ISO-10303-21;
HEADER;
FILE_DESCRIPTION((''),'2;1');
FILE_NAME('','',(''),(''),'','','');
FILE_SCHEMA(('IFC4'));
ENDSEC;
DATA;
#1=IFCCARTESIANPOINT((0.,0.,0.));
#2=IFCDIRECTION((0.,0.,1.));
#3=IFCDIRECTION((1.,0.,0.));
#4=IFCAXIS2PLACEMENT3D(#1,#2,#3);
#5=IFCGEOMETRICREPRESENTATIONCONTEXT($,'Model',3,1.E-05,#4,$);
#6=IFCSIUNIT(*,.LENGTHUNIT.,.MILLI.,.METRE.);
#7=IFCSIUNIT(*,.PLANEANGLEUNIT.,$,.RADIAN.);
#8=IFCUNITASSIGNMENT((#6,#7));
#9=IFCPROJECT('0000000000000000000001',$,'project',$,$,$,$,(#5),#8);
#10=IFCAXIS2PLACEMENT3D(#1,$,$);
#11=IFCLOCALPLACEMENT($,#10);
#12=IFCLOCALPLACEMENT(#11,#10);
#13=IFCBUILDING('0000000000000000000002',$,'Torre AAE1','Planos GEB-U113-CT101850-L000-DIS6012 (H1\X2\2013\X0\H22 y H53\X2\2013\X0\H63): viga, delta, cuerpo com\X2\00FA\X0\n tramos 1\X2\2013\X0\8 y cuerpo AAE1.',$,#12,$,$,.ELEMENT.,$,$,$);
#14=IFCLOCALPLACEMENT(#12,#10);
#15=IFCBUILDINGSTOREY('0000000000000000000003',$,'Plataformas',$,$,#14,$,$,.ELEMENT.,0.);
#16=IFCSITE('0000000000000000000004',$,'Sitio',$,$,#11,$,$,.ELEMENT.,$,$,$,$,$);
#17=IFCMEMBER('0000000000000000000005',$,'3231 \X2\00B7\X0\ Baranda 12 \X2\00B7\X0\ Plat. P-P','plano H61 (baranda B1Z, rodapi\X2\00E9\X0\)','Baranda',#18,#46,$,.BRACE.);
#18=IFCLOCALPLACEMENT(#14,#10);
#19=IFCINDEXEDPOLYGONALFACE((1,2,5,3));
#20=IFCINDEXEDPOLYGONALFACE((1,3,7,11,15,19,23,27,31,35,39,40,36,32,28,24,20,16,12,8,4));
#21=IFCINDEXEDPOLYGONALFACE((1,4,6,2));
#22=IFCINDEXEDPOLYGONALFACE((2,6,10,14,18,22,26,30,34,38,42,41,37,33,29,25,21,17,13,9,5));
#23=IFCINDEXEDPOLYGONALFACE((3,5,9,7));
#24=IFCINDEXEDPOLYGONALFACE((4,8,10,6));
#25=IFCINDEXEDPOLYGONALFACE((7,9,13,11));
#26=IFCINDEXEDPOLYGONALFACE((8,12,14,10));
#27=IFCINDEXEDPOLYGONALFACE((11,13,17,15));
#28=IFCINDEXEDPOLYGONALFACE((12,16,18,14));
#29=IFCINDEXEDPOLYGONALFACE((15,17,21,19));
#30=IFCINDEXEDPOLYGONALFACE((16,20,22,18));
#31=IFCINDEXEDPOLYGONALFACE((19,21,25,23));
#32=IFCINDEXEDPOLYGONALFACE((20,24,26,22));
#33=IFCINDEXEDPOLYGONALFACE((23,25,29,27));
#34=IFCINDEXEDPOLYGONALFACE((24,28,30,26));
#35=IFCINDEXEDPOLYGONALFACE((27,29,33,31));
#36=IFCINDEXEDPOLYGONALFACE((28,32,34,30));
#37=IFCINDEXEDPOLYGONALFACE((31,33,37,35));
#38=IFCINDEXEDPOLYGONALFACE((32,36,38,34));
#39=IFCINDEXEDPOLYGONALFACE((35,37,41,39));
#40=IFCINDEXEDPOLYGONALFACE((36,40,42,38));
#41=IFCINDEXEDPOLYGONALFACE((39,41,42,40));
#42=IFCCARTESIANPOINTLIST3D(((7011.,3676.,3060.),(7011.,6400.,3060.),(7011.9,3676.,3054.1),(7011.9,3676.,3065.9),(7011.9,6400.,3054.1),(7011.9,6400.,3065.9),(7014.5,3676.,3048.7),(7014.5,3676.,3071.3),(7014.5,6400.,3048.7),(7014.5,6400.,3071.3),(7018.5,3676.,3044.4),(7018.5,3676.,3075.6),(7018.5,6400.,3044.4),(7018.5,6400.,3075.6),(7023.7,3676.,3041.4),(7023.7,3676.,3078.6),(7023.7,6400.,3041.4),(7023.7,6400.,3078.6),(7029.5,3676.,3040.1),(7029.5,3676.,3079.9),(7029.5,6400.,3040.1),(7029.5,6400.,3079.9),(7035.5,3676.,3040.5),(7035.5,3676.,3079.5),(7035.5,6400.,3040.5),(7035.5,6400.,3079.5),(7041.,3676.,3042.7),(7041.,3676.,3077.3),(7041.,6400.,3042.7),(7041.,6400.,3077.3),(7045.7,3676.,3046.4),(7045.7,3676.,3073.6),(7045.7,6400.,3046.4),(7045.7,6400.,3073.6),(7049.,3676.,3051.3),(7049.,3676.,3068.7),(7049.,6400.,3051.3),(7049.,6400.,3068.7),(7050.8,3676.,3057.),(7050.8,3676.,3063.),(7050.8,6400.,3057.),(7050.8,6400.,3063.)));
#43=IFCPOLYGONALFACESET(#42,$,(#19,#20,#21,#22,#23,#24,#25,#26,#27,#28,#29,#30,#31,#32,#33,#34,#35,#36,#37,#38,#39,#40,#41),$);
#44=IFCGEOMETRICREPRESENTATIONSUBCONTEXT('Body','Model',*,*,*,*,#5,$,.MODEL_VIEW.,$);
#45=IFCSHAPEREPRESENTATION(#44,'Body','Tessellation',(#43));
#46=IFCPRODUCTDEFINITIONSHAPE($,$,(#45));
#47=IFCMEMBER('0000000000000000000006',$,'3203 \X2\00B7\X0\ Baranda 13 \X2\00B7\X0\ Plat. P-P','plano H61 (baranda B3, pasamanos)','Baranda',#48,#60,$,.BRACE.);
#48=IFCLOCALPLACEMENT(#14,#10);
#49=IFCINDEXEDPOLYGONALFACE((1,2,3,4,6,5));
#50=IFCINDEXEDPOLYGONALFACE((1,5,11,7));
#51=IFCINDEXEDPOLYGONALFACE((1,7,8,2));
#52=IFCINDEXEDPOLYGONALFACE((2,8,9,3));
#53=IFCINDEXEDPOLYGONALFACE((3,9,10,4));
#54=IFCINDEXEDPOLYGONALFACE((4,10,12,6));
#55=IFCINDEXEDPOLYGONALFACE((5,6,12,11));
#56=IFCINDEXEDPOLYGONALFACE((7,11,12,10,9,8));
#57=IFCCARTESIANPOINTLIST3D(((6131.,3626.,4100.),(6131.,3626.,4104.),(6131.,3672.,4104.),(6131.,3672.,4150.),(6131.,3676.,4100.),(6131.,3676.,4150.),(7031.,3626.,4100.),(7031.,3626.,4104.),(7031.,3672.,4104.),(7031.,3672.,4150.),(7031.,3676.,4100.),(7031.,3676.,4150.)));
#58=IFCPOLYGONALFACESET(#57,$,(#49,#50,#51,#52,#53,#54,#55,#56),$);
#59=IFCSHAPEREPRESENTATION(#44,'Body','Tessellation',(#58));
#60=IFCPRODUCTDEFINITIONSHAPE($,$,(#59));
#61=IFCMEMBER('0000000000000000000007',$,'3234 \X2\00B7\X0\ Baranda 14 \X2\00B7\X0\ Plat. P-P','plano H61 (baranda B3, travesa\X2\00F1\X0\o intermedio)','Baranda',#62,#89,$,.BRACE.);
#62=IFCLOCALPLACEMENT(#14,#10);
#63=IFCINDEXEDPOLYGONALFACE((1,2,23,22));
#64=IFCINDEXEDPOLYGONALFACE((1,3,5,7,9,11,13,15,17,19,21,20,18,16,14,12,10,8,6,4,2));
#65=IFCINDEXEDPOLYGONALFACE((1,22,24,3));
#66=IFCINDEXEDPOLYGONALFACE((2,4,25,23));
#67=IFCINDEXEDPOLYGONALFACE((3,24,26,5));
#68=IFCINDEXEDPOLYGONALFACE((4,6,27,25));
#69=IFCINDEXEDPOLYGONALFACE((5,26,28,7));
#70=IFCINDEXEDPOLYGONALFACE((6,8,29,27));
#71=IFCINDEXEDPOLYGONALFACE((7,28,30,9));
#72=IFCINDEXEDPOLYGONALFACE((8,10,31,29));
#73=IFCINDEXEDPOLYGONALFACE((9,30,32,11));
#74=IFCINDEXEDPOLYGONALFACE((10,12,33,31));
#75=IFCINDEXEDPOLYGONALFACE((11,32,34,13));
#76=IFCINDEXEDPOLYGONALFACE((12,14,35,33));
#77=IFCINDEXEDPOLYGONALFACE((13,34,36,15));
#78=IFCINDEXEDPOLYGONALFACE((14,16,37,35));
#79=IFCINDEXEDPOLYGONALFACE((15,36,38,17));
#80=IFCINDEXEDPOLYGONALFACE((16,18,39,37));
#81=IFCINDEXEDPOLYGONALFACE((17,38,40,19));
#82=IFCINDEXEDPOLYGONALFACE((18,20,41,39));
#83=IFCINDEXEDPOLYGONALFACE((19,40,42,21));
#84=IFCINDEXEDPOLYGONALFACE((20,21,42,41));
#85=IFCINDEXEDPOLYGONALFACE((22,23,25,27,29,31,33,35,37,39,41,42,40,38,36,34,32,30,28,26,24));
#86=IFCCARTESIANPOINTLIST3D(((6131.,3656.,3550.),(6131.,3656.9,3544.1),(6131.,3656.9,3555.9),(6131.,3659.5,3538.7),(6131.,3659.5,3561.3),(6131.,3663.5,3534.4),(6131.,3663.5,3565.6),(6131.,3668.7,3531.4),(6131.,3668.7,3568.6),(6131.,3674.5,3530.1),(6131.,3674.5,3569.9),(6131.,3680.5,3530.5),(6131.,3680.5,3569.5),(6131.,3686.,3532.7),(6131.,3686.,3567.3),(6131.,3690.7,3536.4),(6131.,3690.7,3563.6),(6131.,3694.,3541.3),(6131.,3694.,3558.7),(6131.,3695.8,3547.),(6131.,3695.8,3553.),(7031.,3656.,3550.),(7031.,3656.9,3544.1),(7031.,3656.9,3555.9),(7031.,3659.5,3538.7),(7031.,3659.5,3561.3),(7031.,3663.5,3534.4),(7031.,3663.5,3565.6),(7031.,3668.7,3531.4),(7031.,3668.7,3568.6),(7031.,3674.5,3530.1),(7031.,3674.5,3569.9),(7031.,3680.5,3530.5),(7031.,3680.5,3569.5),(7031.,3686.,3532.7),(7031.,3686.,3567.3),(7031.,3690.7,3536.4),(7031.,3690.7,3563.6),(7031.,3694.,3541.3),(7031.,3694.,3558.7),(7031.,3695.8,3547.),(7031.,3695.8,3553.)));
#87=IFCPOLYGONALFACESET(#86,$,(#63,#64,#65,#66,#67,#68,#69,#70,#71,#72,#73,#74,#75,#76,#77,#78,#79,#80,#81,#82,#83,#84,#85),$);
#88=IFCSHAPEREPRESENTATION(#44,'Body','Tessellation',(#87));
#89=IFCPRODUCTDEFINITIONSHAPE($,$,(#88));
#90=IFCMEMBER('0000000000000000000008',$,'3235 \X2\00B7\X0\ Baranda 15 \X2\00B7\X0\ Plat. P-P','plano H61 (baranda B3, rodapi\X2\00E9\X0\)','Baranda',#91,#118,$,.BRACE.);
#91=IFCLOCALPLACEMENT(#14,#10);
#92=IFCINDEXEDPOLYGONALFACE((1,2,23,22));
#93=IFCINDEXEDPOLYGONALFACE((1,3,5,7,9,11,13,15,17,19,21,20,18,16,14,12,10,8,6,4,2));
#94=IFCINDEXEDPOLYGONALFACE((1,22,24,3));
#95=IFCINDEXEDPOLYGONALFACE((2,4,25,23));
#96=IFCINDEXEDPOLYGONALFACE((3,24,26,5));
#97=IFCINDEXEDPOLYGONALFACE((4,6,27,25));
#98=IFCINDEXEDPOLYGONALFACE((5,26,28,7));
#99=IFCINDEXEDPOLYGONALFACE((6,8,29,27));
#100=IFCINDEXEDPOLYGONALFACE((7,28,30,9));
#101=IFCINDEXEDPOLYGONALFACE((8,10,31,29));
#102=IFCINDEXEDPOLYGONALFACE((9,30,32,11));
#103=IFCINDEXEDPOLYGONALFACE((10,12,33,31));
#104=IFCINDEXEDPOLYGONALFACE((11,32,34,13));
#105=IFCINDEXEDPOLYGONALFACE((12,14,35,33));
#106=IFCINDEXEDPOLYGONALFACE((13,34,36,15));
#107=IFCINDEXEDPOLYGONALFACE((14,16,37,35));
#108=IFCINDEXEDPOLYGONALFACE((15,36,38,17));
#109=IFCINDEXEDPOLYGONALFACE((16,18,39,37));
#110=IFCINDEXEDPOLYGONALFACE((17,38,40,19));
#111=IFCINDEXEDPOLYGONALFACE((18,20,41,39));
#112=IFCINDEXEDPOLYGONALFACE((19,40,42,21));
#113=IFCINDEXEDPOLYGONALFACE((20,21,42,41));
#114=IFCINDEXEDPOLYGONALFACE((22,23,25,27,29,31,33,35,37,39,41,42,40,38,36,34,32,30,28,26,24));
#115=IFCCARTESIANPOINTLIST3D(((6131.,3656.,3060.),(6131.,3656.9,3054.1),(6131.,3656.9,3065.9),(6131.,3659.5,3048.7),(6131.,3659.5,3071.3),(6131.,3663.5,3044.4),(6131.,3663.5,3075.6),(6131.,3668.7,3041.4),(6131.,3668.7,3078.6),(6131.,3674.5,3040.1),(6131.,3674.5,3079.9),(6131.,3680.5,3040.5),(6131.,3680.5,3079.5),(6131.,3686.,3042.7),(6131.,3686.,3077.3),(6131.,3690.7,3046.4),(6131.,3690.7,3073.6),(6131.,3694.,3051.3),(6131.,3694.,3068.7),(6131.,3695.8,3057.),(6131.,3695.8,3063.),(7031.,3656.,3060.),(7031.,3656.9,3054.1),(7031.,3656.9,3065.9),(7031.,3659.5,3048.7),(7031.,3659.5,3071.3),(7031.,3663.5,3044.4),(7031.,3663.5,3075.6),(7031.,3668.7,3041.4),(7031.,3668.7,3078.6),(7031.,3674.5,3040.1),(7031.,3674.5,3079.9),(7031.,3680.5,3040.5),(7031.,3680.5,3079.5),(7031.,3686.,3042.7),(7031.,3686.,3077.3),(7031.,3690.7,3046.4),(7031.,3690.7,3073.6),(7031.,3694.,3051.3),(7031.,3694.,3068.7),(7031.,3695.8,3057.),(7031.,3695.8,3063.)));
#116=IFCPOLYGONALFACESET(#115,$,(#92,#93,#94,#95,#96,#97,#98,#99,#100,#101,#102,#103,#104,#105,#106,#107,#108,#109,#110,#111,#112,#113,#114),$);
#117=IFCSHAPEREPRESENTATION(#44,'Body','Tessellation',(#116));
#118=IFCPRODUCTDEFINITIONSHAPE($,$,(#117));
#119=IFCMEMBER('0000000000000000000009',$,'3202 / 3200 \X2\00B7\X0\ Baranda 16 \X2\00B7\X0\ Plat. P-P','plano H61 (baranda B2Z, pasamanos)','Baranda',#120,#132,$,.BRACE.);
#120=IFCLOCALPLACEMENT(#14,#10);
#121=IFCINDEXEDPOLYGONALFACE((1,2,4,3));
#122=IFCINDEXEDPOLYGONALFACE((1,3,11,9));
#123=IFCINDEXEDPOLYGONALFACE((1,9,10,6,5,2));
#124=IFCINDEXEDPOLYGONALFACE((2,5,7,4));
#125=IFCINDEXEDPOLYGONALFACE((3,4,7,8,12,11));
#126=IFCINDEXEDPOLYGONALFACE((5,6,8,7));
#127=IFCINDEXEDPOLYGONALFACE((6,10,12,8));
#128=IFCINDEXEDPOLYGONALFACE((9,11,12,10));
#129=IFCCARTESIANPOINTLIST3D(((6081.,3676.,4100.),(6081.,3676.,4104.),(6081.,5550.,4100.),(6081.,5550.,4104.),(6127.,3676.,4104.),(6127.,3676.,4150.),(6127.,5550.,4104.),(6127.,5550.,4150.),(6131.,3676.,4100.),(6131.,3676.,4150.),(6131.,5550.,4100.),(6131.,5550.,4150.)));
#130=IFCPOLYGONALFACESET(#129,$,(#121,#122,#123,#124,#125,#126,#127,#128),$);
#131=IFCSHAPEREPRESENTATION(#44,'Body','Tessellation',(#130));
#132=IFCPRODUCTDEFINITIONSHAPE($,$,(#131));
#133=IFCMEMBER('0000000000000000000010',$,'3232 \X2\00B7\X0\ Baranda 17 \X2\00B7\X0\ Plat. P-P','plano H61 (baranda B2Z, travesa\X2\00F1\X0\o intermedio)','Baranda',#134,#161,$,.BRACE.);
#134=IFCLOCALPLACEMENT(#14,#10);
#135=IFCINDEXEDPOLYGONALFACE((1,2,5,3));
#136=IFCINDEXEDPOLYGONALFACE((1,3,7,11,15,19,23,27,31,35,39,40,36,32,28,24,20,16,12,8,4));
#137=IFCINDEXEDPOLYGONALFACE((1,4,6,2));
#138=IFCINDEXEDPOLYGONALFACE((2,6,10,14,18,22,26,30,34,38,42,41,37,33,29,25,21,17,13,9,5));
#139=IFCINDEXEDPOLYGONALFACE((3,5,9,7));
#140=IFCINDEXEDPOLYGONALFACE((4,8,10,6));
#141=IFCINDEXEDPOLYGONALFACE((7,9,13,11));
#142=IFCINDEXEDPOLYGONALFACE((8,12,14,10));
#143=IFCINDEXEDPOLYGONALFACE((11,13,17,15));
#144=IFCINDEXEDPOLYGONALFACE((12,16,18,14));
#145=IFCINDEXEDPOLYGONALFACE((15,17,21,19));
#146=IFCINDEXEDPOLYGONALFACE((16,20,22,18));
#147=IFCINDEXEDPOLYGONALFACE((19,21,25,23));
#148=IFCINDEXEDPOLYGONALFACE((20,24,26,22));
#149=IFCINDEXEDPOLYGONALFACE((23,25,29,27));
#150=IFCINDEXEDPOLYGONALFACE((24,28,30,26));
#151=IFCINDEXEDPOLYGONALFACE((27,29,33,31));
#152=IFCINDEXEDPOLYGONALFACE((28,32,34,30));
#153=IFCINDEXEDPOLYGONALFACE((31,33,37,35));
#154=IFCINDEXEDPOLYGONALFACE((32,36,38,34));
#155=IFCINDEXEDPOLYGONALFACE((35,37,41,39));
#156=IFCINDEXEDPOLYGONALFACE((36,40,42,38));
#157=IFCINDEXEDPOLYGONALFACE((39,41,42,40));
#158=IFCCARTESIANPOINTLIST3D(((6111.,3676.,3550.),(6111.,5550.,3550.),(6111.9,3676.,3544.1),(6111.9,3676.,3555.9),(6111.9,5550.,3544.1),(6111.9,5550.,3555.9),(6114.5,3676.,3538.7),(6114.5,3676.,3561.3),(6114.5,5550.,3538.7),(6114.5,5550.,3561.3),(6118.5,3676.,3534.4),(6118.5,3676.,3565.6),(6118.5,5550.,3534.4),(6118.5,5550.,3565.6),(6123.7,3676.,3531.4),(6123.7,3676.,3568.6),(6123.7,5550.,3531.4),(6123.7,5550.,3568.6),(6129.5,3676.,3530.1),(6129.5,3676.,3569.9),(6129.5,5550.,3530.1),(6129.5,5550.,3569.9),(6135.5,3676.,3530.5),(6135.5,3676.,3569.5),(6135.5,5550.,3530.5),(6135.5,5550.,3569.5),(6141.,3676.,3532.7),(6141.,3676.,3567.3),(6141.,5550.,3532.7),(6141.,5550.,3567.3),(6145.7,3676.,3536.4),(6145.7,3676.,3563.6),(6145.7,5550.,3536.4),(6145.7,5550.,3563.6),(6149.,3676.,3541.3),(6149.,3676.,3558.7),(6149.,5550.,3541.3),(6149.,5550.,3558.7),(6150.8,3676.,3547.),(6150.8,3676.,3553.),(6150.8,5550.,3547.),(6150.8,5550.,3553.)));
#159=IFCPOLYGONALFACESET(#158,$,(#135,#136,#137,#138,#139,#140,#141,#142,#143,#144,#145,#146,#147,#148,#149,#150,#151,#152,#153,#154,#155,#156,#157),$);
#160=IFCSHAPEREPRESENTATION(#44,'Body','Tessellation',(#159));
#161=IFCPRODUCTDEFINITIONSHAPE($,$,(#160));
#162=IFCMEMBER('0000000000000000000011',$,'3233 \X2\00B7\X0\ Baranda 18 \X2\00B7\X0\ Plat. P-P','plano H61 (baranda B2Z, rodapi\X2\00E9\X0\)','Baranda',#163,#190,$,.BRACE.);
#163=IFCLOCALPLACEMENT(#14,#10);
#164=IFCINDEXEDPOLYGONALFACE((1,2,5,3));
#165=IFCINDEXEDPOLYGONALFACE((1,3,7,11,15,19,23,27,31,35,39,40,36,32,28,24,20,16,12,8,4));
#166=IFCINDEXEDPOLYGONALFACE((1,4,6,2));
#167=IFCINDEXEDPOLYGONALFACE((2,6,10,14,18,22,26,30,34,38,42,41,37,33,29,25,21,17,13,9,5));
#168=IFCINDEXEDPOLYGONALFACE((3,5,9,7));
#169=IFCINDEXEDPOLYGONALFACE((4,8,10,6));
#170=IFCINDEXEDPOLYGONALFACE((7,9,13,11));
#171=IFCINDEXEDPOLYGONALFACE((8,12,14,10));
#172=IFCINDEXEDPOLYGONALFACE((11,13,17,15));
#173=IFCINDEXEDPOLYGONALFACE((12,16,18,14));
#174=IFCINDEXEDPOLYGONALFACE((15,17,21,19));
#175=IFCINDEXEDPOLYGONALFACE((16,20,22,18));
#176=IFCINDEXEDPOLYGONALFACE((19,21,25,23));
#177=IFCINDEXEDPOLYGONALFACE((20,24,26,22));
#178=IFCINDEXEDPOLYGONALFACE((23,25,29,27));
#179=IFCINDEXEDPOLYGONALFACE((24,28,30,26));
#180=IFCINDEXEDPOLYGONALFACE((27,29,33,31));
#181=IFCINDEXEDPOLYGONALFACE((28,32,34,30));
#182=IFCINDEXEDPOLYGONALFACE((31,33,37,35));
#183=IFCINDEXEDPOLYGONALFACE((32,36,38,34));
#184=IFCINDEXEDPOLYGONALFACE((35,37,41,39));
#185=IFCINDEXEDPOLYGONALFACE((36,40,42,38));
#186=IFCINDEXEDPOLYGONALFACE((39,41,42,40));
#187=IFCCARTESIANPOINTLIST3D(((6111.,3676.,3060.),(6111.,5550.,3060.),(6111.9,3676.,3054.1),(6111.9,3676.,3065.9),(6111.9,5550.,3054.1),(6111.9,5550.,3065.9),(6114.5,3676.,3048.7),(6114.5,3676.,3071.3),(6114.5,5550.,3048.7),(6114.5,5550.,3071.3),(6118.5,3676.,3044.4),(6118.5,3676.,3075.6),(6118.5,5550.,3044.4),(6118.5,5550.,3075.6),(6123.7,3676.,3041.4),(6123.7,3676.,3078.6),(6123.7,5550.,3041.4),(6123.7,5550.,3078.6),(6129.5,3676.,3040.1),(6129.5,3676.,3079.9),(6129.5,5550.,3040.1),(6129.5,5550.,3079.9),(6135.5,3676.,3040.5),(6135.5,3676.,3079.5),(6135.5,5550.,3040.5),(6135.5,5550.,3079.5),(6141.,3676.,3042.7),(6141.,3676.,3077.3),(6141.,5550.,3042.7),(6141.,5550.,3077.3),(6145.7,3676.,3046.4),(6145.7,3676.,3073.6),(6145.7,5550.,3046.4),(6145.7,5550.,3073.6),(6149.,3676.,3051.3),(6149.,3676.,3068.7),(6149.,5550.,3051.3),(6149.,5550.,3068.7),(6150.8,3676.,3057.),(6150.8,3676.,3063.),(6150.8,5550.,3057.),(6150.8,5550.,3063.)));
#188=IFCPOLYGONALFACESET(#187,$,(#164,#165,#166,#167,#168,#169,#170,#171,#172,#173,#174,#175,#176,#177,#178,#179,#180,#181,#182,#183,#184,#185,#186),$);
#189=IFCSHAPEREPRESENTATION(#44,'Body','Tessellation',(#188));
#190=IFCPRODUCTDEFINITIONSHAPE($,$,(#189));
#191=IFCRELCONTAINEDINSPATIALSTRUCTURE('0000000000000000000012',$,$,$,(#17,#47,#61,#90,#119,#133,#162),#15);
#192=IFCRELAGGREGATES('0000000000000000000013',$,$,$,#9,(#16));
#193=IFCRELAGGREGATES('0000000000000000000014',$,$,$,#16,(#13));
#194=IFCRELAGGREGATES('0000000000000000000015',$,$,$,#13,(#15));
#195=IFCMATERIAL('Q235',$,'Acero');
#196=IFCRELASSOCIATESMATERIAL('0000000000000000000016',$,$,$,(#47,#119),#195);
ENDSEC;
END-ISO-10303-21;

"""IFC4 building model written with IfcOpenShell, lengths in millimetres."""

from ifc_helpers import new_model, si_unit, frame, frame_2d, origin, origin_with_axes, place, context, subcontext, project, spatial, circle, l_section, extrude, material, element, save


model = new_model("IFC4")

# Units and contexts
model_context = context("Model", 3, precision=1e-05, world=origin_with_axes())
body_context = subcontext(model_context, "Body", "Model", "MODEL_VIEW")
ifc_project = project(units=[si_unit("LENGTHUNIT", "METRE", prefix="MILLI"), si_unit("PLANEANGLEUNIT", "RADIAN")], contexts=[model_context])

# Site, building, storey
site_placement = place(None, origin())
site = spatial("IfcSite", under=ifc_project, at=site_placement, Name="Sitio", CompositionType="ELEMENT")
building_placement = place(site_placement, origin())
building = spatial("IfcBuilding", under=site, at=building_placement, Name="Torre AAE1", Description="Planos GEB-U113-CT101850-L000-DIS6012 (H1–H22 y H53–H63): viga, delta, cuerpo común tramos 1–8 y cuerpo AAE1.", CompositionType="ELEMENT")
storey_placement = place(building_placement, origin())
storey = spatial("IfcBuildingStorey", under=building, at=storey_placement, Name="Plataformas", CompositionType="ELEMENT", Elevation=0.0)

# Members
ifc_material = material(Name="Q235", Category="Acero")
for number, where, z_axis, x_axis, name in (
    (1, (7031.0, 6400.0, 3060.0), (0.0, -1.0, 0.0), (-1.0, 0.0, 0.0), "3231 · Baranda 12 · Plat. P-P"),
):
    element("IfcMember", number, at=place(storey_placement, frame(where, z_axis=z_axis, x_axis=x_axis)), inside=storey, Name=name, Description="plano H61 (baranda B1Z, rodapié)", ObjectType="Baranda", PredefinedType="BRACE", context=body_context, shape_type="SweptSolid", body=[
        extrude(circle(Radius=20.0), None, (0.0, 0.0, 1.0), 2724.0),
    ])
member_1_placement = place(storey_placement, frame((7031.0, 3676.0, 4100.0), z_axis=(-1.0, 0.0, 0.0), x_axis=(0.0, -1.0, 0.0)))
element("IfcMember", 2, at=member_1_placement, inside=storey, material=ifc_material, Name="3203 · Baranda 13 · Plat. P-P", Description="plano H61 (baranda B3, pasamanos)", ObjectType="Baranda", PredefinedType="BRACE", context=body_context, shape_type="SweptSolid", body=[
    extrude(l_section(Depth=50.0, Width=50.0, Thickness=4.0, at=frame_2d((25.0, 25.0))), None, (0.0, 0.0, 1.0), 900.0),
])
for number, where, z_axis, x_axis, name, description in (
    (3, (7031.0, 3676.0, 3550.0), (-1.0, 0.0, 0.0), (0.0, -1.0, 0.0), "3234 · Baranda 14 · Plat. P-P", "plano H61 (baranda B3, travesaño intermedio)"),
    (4, (7031.0, 3676.0, 3060.0), (-1.0, 0.0, 0.0), (0.0, -1.0, 0.0), "3235 · Baranda 15 · Plat. P-P", "plano H61 (baranda B3, rodapié)"),
):
    element("IfcMember", number, at=place(storey_placement, frame(where, z_axis=z_axis, x_axis=x_axis)), inside=storey, Name=name, Description=description, ObjectType="Baranda", PredefinedType="BRACE", context=body_context, shape_type="SweptSolid", body=[
        extrude(circle(Radius=20.0), None, (0.0, 0.0, 1.0), 900.0),
    ])
member_2_placement = place(storey_placement, frame((6131.0, 3676.0, 4100.0), z_axis=(0.0, 1.0, 0.0), x_axis=(-1.0, 0.0, 0.0)))
element("IfcMember", 5, at=member_2_placement, inside=storey, material=ifc_material, Name="3202 / 3200 · Baranda 16 · Plat. P-P", Description="plano H61 (baranda B2Z, pasamanos)", ObjectType="Baranda", PredefinedType="BRACE", context=body_context, shape_type="SweptSolid", body=[
    extrude(l_section(Depth=50.0, Width=50.0, Thickness=4.0, at=frame_2d((25.0, 25.0))), None, (0.0, 0.0, 1.0), 1874.0),
])
for number, where, z_axis, x_axis, name, description in (
    (6, (6131.0, 3676.0, 3550.0), (0.0, 1.0, 0.0), (-1.0, 0.0, 0.0), "3232 · Baranda 17 · Plat. P-P", "plano H61 (baranda B2Z, travesaño intermedio)"),
    (7, (6131.0, 3676.0, 3060.0), (0.0, 1.0, 0.0), (-1.0, 0.0, 0.0), "3233 · Baranda 18 · Plat. P-P", "plano H61 (baranda B2Z, rodapié)"),
):
    element("IfcMember", number, at=place(storey_placement, frame(where, z_axis=z_axis, x_axis=x_axis)), inside=storey, Name=name, Description=description, ObjectType="Baranda", PredefinedType="BRACE", context=body_context, shape_type="SweptSolid", body=[
        extrude(circle(Radius=20.0), None, (0.0, 0.0, 1.0), 1874.0),
    ])

save(model, "model.ifc")
